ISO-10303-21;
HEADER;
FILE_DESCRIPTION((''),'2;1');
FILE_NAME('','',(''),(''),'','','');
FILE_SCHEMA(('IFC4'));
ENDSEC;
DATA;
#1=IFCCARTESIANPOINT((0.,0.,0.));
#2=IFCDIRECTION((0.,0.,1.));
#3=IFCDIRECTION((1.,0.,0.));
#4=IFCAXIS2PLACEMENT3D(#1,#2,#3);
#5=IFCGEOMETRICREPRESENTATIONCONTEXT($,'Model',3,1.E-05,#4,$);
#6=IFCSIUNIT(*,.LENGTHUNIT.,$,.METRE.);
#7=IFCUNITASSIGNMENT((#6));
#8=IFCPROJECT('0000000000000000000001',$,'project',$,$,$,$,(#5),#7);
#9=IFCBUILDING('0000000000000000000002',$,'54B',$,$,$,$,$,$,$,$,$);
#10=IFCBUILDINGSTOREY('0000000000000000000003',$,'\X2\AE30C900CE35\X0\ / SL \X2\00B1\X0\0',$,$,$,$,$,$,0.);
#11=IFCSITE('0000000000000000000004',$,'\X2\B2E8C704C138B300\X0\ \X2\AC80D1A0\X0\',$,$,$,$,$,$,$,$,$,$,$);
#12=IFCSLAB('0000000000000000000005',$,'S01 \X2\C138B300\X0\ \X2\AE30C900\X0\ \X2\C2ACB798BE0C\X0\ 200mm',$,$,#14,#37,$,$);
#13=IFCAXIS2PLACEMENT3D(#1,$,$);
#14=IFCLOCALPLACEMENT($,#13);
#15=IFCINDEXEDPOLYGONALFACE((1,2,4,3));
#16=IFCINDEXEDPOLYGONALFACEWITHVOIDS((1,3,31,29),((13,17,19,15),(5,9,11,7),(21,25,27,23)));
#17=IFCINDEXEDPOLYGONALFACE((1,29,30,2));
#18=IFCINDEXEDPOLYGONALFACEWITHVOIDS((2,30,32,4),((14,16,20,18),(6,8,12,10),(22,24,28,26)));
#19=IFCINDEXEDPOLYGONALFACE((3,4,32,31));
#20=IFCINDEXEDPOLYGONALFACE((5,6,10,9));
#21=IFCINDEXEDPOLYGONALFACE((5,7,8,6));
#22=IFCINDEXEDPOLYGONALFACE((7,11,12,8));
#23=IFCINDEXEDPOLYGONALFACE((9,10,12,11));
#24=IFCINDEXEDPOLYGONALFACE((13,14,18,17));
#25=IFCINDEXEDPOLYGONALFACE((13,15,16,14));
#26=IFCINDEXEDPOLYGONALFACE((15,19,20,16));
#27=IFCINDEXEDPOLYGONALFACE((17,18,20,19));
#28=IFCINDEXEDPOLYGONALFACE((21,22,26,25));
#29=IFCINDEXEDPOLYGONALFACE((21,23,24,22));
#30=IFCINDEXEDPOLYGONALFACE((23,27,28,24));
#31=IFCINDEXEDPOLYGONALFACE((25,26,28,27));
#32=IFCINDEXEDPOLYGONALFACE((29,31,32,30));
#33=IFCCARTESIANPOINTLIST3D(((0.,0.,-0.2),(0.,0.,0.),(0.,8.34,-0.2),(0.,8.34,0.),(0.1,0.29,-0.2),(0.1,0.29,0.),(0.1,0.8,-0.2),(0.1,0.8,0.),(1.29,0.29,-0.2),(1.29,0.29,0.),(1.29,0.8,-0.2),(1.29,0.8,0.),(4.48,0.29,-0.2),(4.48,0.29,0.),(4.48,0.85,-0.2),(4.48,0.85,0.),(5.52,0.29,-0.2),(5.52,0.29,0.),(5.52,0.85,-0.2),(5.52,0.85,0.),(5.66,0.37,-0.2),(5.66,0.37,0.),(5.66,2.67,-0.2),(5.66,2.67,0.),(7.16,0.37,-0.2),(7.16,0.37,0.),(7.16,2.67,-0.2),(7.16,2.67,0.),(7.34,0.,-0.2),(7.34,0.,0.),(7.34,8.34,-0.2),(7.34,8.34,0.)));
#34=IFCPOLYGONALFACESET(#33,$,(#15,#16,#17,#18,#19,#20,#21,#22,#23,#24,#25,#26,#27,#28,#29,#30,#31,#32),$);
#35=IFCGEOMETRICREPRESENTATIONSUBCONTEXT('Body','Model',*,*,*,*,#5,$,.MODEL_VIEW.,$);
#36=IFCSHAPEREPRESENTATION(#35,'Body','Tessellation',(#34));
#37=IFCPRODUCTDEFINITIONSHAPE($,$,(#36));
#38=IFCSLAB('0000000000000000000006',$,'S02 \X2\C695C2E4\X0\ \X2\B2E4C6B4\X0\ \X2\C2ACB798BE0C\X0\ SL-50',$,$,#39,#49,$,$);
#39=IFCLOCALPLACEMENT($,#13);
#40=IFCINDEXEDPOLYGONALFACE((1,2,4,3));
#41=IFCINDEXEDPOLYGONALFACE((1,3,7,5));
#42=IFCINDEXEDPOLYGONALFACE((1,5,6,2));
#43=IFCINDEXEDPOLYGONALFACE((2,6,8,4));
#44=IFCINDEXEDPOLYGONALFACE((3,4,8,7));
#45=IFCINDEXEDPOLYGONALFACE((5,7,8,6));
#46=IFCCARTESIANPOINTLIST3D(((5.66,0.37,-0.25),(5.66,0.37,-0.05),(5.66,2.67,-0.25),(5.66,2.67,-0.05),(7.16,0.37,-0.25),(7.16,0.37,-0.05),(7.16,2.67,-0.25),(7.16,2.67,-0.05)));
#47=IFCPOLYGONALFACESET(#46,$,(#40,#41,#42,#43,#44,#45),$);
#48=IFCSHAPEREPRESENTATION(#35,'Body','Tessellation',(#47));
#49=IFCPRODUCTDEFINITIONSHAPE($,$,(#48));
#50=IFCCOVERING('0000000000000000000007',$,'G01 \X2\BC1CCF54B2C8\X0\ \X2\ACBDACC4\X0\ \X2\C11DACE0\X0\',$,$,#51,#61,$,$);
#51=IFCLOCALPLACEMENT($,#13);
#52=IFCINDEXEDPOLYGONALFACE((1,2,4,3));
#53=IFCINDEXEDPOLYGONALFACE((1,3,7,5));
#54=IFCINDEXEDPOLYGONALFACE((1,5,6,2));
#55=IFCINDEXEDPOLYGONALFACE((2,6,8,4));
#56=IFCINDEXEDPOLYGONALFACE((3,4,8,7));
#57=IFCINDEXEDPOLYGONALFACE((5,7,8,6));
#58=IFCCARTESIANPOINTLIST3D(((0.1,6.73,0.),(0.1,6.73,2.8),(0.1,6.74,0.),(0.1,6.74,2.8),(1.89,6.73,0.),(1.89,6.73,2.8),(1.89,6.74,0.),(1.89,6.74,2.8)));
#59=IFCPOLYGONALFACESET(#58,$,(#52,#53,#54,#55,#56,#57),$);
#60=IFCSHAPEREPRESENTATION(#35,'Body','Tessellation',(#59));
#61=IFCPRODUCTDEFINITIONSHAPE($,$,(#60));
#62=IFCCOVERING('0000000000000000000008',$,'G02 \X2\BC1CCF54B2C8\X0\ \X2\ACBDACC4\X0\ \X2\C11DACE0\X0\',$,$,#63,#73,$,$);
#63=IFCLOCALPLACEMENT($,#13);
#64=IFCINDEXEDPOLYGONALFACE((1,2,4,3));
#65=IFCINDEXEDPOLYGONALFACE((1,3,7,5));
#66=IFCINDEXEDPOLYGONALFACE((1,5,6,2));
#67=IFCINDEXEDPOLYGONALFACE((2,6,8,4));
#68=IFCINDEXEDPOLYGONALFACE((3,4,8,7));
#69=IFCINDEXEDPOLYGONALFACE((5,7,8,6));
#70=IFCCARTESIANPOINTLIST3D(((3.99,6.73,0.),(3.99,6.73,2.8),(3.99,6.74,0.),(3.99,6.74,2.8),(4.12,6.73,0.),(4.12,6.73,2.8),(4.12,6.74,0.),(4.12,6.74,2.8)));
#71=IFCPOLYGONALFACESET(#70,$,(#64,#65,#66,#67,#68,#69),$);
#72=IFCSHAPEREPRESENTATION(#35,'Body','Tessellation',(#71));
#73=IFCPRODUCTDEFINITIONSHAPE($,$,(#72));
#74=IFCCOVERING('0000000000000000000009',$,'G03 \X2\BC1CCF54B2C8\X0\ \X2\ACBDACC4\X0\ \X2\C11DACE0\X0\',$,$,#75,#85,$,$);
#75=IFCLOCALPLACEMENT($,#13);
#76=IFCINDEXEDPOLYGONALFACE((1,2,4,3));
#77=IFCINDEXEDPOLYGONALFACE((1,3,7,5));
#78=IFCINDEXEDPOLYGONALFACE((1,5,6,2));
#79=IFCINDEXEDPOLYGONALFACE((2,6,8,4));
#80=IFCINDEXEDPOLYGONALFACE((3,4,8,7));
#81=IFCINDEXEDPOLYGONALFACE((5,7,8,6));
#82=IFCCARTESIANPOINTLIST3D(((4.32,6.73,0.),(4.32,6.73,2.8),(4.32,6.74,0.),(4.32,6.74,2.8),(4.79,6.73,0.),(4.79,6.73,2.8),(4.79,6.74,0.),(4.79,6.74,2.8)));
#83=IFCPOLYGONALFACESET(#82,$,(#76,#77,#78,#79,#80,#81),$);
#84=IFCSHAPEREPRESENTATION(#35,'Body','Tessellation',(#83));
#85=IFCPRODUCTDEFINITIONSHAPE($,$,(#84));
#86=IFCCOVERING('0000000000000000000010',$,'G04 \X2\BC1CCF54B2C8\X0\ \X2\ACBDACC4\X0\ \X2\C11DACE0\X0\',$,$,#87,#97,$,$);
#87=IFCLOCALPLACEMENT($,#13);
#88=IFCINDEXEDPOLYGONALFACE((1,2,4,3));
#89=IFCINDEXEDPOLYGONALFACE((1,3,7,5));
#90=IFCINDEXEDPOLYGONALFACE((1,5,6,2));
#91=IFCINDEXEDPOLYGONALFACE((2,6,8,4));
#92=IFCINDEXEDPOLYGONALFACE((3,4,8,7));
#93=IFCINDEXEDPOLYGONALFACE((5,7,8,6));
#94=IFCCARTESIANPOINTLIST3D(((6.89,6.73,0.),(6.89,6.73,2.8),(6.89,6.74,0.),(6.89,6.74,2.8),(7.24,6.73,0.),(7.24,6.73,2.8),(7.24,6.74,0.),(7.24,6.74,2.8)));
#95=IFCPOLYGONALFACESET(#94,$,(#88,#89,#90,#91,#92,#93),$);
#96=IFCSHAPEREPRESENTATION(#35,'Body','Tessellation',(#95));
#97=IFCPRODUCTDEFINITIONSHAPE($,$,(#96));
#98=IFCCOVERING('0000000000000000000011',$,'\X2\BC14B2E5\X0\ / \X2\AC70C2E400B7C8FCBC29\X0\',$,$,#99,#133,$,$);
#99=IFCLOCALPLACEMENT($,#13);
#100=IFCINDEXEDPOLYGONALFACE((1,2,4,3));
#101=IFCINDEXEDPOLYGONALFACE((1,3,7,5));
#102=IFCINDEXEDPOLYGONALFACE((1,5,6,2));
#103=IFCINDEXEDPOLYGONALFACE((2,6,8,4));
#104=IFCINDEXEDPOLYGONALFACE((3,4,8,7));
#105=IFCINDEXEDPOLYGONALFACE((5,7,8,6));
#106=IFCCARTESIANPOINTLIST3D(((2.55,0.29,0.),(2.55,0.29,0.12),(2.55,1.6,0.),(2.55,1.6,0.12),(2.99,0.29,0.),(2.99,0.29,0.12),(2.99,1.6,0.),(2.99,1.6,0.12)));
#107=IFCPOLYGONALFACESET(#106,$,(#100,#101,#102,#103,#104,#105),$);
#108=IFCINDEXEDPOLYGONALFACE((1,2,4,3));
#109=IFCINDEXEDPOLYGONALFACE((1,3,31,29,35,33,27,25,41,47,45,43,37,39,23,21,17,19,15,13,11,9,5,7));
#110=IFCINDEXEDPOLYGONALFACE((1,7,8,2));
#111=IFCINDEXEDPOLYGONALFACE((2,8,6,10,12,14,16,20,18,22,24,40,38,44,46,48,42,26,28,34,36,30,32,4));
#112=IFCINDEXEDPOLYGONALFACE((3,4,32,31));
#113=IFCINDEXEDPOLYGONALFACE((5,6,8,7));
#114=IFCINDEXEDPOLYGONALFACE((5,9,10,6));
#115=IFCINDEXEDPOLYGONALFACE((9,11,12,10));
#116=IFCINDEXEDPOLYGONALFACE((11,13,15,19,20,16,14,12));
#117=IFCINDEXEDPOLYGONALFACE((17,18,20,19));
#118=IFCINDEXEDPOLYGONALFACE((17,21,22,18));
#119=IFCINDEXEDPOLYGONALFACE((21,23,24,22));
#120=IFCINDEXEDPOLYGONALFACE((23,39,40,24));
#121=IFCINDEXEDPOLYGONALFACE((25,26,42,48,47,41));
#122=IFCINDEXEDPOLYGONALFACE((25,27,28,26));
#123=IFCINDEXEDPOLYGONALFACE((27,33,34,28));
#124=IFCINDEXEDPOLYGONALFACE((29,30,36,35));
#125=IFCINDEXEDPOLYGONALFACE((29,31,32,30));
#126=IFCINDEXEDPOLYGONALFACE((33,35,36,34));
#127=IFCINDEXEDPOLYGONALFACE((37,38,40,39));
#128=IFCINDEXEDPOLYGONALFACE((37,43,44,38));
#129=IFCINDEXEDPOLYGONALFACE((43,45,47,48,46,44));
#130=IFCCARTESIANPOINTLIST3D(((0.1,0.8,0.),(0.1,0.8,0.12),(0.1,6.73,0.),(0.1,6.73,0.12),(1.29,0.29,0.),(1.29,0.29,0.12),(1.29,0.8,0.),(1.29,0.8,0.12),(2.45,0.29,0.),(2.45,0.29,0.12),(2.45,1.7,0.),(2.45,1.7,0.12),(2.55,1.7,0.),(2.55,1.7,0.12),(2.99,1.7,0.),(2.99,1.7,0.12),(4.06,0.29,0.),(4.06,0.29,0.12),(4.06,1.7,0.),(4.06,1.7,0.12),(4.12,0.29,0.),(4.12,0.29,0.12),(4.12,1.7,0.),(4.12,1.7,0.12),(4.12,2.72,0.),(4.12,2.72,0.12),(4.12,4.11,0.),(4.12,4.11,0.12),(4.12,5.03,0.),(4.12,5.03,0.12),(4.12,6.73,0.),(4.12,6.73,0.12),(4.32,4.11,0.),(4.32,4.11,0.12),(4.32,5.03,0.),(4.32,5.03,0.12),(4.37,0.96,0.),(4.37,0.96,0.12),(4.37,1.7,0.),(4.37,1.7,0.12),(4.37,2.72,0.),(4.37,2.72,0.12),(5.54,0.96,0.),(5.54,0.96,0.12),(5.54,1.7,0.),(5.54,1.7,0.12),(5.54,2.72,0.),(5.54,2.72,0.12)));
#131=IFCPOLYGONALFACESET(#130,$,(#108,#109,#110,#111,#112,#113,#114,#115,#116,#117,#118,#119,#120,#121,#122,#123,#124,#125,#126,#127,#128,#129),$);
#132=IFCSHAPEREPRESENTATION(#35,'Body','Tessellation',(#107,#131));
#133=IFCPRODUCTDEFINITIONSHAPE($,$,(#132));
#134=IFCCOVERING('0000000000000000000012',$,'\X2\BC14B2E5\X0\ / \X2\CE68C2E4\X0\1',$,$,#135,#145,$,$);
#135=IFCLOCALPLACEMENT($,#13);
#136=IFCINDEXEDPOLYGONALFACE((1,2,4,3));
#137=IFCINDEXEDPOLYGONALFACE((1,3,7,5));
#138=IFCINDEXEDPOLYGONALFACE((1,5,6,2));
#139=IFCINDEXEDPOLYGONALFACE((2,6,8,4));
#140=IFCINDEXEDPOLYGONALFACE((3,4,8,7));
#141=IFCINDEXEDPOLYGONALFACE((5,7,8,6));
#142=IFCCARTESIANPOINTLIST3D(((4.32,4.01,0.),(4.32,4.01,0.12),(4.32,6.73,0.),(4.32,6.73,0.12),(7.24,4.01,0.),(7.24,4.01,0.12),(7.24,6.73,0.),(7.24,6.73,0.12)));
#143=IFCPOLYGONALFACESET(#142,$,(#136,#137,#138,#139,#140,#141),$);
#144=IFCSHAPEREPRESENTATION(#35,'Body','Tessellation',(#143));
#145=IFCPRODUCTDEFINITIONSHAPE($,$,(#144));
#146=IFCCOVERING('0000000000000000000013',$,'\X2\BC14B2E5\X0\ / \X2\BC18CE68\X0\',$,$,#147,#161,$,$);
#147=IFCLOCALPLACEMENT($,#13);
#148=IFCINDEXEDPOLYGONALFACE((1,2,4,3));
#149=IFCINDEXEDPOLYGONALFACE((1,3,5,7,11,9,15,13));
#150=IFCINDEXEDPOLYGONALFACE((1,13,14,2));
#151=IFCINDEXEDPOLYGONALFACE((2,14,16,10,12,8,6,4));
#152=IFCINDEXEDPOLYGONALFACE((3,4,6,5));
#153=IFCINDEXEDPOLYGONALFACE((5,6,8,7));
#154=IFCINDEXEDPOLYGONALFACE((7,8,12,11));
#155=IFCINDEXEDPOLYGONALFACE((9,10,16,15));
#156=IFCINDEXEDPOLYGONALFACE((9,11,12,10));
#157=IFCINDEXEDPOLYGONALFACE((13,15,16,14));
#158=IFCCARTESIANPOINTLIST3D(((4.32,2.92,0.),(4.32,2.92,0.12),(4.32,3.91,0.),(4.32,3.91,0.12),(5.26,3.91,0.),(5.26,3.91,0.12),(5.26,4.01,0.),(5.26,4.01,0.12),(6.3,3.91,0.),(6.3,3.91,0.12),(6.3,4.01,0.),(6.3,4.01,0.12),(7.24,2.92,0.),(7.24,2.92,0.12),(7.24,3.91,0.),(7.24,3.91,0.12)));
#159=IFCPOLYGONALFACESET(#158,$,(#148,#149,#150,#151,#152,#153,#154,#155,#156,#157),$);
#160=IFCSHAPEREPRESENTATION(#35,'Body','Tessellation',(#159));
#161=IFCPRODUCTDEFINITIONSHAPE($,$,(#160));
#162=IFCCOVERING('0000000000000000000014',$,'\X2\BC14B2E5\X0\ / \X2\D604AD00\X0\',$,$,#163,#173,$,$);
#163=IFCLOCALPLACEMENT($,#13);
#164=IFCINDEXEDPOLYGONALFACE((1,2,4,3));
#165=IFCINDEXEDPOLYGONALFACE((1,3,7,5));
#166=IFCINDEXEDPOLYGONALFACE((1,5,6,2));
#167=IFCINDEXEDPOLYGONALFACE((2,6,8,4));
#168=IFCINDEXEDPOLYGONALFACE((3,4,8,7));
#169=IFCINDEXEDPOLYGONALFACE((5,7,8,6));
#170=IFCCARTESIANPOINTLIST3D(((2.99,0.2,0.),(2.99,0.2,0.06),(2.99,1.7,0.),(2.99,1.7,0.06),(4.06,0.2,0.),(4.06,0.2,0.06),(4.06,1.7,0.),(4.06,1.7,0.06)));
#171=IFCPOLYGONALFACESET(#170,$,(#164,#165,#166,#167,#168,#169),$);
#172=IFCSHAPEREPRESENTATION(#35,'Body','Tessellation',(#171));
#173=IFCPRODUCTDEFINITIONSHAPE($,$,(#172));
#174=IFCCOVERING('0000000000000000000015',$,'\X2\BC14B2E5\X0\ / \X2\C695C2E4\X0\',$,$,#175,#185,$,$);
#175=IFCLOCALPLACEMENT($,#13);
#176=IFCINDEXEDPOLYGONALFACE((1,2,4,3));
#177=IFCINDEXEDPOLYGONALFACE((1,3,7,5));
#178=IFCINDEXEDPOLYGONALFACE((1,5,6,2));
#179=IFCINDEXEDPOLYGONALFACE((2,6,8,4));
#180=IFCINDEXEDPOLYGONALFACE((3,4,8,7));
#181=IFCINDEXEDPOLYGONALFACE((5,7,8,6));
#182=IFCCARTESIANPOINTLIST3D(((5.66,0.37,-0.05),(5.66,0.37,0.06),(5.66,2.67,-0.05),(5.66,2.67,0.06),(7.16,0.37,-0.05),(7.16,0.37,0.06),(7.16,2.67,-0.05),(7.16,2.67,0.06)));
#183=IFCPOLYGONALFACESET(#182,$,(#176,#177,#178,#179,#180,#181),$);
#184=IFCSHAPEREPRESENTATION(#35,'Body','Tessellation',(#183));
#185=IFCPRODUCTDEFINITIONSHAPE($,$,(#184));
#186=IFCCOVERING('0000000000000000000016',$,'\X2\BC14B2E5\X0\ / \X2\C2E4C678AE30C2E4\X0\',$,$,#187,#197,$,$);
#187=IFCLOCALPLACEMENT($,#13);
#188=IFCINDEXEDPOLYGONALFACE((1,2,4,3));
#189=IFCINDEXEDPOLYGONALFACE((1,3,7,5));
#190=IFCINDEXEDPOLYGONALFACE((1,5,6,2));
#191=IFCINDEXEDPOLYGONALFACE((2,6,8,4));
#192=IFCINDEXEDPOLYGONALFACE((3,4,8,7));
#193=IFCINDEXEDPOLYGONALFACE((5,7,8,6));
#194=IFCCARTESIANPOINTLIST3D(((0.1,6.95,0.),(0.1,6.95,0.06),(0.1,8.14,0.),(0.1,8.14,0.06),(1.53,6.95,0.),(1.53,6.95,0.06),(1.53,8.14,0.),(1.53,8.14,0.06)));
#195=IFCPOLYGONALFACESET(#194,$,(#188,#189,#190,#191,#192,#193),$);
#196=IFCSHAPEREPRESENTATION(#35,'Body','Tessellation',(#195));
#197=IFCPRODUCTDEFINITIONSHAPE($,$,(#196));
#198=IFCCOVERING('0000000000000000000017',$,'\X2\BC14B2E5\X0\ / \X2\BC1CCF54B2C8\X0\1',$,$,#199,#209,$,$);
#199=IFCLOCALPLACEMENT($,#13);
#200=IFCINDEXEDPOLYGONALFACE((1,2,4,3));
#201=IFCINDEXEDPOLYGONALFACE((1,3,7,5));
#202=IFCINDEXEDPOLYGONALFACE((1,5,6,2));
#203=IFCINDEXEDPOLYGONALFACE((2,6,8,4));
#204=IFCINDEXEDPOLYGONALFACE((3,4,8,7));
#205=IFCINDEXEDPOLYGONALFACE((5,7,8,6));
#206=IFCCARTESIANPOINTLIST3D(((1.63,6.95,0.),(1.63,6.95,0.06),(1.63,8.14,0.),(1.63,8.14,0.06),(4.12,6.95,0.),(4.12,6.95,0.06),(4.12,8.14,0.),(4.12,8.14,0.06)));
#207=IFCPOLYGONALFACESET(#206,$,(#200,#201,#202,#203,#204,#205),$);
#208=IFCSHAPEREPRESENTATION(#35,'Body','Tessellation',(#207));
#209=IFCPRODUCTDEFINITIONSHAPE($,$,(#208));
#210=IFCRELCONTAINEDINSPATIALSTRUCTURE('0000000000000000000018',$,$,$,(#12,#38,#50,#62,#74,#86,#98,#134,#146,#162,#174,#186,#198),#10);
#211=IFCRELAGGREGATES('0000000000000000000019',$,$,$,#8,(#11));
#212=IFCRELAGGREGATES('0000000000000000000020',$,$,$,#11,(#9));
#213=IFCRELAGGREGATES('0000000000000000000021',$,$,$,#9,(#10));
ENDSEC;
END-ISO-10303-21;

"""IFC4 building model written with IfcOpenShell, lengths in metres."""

from ifc_helpers import new_model, si_unit, frame, origin, origin_with_axes, place, context, subcontext, project, spatial, polyline, outline, extrude, element, save


model = new_model("IFC4")

# Units and contexts
model_context = context("Model", 3, precision=1e-05, world=origin_with_axes())
body_context = subcontext(model_context, "Body", "Model", "MODEL_VIEW")
ifc_project = project(units=[si_unit("LENGTHUNIT", "METRE")], contexts=[model_context])

# Site, building, storey
site = spatial("IfcSite", under=ifc_project, Name="단위세대 검토")
building = spatial("IfcBuilding", under=site, Name="54B")
storey = spatial("IfcBuildingStorey", under=building, Name="기준층 / SL ±0", Elevation=0.0)

# Slabs
slab_1_placement = place(None, origin_with_axes())
element("IfcSlab", 1, at=slab_1_placement, inside=storey, Name="S01 세대 기준 슬래브 200mm", context=body_context, shape_type="SweptSolid", body=[
    extrude(outline(polyline([(0.0, 0.0), (0.0, 8.34), (7.34, 8.34), (7.34, 0.0), (0.0, 0.0)]), holes=[polyline([(0.1, 0.8), (0.1, 0.29), (1.29, 0.29), (1.29, 0.8), (0.1, 0.8)]), polyline([(5.52, 0.85), (4.48, 0.85), (4.48, 0.29), (5.52, 0.29), (5.52, 0.85)]), polyline([(5.66, 0.37), (7.16, 0.37), (7.16, 2.67), (5.66, 2.67), (5.66, 0.37)])]), frame((0.0, 0.0, -0.2)), (0.0, 0.0, 1.0), 0.2),
])
slab_2_placement = place(None, origin_with_axes())
element("IfcSlab", 2, at=slab_2_placement, inside=storey, Name="S02 욕실 다운 슬래브 SL-50", context=body_context, shape_type="SweptSolid", body=[
    extrude(outline(polyline([(7.16, 0.37), (7.16, 2.67), (5.66, 2.67), (5.66, 0.37), (7.16, 0.37)])), frame((0.0, 0.0, -0.25)), (0.0, 0.0, 1.0), 0.2),
])

# Coverings
covering_1_placement = place(None, origin_with_axes())
element("IfcCovering", 3, at=covering_1_placement, inside=storey, Name="G01 발코니 경계 석고", context=body_context, shape_type="SweptSolid", body=[
    extrude(outline(polyline([(1.89, 6.73), (1.89, 6.74), (0.1, 6.74), (0.1, 6.73), (1.89, 6.73)])), origin(), (0.0, 0.0, 1.0), 2.8),
])
covering_2_placement = place(None, origin_with_axes())
element("IfcCovering", 4, at=covering_2_placement, inside=storey, Name="G02 발코니 경계 석고", context=body_context, shape_type="SweptSolid", body=[
    extrude(outline(polyline([(4.12, 6.73), (4.12, 6.74), (3.99, 6.74), (3.99, 6.73), (4.12, 6.73)])), origin(), (0.0, 0.0, 1.0), 2.8),
])
covering_3_placement = place(None, origin_with_axes())
element("IfcCovering", 5, at=covering_3_placement, inside=storey, Name="G03 발코니 경계 석고", context=body_context, shape_type="SweptSolid", body=[
    extrude(outline(polyline([(4.79, 6.73), (4.79, 6.74), (4.32, 6.74), (4.32, 6.73), (4.79, 6.73)])), origin(), (0.0, 0.0, 1.0), 2.8),
])
covering_4_placement = place(None, origin_with_axes())
element("IfcCovering", 6, at=covering_4_placement, inside=storey, Name="G04 발코니 경계 석고", context=body_context, shape_type="SweptSolid", body=[
    extrude(outline(polyline([(7.24, 6.73), (7.24, 6.74), (6.89, 6.74), (6.89, 6.73), (7.24, 6.73)])), origin(), (0.0, 0.0, 1.0), 2.8),
])
covering_5_placement = place(None, origin_with_axes())
element("IfcCovering", 7, at=covering_5_placement, inside=storey, Name="바닥 / 거실·주방", context=body_context, shape_type="SweptSolid", body=[
    extrude(outline(polyline([(2.99, 1.6), (2.99, 0.29), (2.55, 0.29), (2.55, 1.6), (2.99, 1.6)])), origin(), (0.0, 0.0, 1.0), 0.12),
    extrude(outline(polyline([(4.37, 1.7), (4.12, 1.7), (4.12, 0.29), (4.06, 0.29), (4.06, 1.7), (2.99, 1.7), (2.55, 1.7), (2.45, 1.7), (2.45, 0.29), (1.29, 0.29), (1.29, 0.8), (0.1, 0.8), (0.1, 6.73), (4.12, 6.73), (4.12, 5.03), (4.32, 5.03), (4.32, 4.11), (4.12, 4.11), (4.12, 2.72), (4.37, 2.72), (5.54, 2.72), (5.54, 1.7), (5.54, 0.96), (4.37, 0.96), (4.37, 1.7)])), origin(), (0.0, 0.0, 1.0), 0.12),
])
covering_6_placement = place(None, origin_with_axes())
element("IfcCovering", 8, at=covering_6_placement, inside=storey, Name="바닥 / 침실1", context=body_context, shape_type="SweptSolid", body=[
    extrude(outline(polyline([(7.24, 4.01), (7.24, 6.73), (4.32, 6.73), (4.32, 4.01), (7.24, 4.01)])), origin(), (0.0, 0.0, 1.0), 0.12),
])
covering_7_placement = place(None, origin_with_axes())
element("IfcCovering", 9, at=covering_7_placement, inside=storey, Name="바닥 / 반침", context=body_context, shape_type="SweptSolid", body=[
    extrude(outline(polyline([(7.24, 3.91), (7.24, 2.92), (4.32, 2.92), (4.32, 3.91), (5.26, 3.91), (5.26, 4.01), (6.3, 4.01), (6.3, 3.91), (7.24, 3.91)])), origin(), (0.0, 0.0, 1.0), 0.12),
])
covering_8_placement = place(None, origin_with_axes())
element("IfcCovering", 10, at=covering_8_placement, inside=storey, Name="바닥 / 현관", context=body_context, shape_type="SweptSolid", body=[
    extrude(outline(polyline([(4.06, 0.2), (4.06, 1.7), (2.99, 1.7), (2.99, 0.2), (4.06, 0.2)])), origin(), (0.0, 0.0, 1.0), 0.06),
])
covering_9_placement = place(None, origin_with_axes())
element("IfcCovering", 11, at=covering_9_placement, inside=storey, Name="바닥 / 욕실", context=body_context, shape_type="SweptSolid", body=[
    extrude(outline(polyline([(7.16, 0.37), (7.16, 2.67), (5.66, 2.67), (5.66, 0.37), (7.16, 0.37)])), frame((0.0, 0.0, -0.05)), (0.0, 0.0, 1.0), 0.11),
])
covering_10_placement = place(None, origin_with_axes())
element("IfcCovering", 12, at=covering_10_placement, inside=storey, Name="바닥 / 실외기실", context=body_context, shape_type="SweptSolid", body=[
    extrude(outline(polyline([(1.53, 6.95), (1.53, 8.14), (0.1, 8.14), (0.1, 6.95), (1.53, 6.95)])), origin(), (0.0, 0.0, 1.0), 0.06),
])
covering_11_placement = place(None, origin_with_axes())
element("IfcCovering", 13, at=covering_11_placement, inside=storey, Name="바닥 / 발코니1", context=body_context, shape_type="SweptSolid", body=[
    extrude(outline(polyline([(4.12, 6.95), (4.12, 8.14), (1.63, 8.14), (1.63, 6.95), (4.12, 6.95)])), origin(), (0.0, 0.0, 1.0), 0.06),
])

save(model, "model.ifc")
